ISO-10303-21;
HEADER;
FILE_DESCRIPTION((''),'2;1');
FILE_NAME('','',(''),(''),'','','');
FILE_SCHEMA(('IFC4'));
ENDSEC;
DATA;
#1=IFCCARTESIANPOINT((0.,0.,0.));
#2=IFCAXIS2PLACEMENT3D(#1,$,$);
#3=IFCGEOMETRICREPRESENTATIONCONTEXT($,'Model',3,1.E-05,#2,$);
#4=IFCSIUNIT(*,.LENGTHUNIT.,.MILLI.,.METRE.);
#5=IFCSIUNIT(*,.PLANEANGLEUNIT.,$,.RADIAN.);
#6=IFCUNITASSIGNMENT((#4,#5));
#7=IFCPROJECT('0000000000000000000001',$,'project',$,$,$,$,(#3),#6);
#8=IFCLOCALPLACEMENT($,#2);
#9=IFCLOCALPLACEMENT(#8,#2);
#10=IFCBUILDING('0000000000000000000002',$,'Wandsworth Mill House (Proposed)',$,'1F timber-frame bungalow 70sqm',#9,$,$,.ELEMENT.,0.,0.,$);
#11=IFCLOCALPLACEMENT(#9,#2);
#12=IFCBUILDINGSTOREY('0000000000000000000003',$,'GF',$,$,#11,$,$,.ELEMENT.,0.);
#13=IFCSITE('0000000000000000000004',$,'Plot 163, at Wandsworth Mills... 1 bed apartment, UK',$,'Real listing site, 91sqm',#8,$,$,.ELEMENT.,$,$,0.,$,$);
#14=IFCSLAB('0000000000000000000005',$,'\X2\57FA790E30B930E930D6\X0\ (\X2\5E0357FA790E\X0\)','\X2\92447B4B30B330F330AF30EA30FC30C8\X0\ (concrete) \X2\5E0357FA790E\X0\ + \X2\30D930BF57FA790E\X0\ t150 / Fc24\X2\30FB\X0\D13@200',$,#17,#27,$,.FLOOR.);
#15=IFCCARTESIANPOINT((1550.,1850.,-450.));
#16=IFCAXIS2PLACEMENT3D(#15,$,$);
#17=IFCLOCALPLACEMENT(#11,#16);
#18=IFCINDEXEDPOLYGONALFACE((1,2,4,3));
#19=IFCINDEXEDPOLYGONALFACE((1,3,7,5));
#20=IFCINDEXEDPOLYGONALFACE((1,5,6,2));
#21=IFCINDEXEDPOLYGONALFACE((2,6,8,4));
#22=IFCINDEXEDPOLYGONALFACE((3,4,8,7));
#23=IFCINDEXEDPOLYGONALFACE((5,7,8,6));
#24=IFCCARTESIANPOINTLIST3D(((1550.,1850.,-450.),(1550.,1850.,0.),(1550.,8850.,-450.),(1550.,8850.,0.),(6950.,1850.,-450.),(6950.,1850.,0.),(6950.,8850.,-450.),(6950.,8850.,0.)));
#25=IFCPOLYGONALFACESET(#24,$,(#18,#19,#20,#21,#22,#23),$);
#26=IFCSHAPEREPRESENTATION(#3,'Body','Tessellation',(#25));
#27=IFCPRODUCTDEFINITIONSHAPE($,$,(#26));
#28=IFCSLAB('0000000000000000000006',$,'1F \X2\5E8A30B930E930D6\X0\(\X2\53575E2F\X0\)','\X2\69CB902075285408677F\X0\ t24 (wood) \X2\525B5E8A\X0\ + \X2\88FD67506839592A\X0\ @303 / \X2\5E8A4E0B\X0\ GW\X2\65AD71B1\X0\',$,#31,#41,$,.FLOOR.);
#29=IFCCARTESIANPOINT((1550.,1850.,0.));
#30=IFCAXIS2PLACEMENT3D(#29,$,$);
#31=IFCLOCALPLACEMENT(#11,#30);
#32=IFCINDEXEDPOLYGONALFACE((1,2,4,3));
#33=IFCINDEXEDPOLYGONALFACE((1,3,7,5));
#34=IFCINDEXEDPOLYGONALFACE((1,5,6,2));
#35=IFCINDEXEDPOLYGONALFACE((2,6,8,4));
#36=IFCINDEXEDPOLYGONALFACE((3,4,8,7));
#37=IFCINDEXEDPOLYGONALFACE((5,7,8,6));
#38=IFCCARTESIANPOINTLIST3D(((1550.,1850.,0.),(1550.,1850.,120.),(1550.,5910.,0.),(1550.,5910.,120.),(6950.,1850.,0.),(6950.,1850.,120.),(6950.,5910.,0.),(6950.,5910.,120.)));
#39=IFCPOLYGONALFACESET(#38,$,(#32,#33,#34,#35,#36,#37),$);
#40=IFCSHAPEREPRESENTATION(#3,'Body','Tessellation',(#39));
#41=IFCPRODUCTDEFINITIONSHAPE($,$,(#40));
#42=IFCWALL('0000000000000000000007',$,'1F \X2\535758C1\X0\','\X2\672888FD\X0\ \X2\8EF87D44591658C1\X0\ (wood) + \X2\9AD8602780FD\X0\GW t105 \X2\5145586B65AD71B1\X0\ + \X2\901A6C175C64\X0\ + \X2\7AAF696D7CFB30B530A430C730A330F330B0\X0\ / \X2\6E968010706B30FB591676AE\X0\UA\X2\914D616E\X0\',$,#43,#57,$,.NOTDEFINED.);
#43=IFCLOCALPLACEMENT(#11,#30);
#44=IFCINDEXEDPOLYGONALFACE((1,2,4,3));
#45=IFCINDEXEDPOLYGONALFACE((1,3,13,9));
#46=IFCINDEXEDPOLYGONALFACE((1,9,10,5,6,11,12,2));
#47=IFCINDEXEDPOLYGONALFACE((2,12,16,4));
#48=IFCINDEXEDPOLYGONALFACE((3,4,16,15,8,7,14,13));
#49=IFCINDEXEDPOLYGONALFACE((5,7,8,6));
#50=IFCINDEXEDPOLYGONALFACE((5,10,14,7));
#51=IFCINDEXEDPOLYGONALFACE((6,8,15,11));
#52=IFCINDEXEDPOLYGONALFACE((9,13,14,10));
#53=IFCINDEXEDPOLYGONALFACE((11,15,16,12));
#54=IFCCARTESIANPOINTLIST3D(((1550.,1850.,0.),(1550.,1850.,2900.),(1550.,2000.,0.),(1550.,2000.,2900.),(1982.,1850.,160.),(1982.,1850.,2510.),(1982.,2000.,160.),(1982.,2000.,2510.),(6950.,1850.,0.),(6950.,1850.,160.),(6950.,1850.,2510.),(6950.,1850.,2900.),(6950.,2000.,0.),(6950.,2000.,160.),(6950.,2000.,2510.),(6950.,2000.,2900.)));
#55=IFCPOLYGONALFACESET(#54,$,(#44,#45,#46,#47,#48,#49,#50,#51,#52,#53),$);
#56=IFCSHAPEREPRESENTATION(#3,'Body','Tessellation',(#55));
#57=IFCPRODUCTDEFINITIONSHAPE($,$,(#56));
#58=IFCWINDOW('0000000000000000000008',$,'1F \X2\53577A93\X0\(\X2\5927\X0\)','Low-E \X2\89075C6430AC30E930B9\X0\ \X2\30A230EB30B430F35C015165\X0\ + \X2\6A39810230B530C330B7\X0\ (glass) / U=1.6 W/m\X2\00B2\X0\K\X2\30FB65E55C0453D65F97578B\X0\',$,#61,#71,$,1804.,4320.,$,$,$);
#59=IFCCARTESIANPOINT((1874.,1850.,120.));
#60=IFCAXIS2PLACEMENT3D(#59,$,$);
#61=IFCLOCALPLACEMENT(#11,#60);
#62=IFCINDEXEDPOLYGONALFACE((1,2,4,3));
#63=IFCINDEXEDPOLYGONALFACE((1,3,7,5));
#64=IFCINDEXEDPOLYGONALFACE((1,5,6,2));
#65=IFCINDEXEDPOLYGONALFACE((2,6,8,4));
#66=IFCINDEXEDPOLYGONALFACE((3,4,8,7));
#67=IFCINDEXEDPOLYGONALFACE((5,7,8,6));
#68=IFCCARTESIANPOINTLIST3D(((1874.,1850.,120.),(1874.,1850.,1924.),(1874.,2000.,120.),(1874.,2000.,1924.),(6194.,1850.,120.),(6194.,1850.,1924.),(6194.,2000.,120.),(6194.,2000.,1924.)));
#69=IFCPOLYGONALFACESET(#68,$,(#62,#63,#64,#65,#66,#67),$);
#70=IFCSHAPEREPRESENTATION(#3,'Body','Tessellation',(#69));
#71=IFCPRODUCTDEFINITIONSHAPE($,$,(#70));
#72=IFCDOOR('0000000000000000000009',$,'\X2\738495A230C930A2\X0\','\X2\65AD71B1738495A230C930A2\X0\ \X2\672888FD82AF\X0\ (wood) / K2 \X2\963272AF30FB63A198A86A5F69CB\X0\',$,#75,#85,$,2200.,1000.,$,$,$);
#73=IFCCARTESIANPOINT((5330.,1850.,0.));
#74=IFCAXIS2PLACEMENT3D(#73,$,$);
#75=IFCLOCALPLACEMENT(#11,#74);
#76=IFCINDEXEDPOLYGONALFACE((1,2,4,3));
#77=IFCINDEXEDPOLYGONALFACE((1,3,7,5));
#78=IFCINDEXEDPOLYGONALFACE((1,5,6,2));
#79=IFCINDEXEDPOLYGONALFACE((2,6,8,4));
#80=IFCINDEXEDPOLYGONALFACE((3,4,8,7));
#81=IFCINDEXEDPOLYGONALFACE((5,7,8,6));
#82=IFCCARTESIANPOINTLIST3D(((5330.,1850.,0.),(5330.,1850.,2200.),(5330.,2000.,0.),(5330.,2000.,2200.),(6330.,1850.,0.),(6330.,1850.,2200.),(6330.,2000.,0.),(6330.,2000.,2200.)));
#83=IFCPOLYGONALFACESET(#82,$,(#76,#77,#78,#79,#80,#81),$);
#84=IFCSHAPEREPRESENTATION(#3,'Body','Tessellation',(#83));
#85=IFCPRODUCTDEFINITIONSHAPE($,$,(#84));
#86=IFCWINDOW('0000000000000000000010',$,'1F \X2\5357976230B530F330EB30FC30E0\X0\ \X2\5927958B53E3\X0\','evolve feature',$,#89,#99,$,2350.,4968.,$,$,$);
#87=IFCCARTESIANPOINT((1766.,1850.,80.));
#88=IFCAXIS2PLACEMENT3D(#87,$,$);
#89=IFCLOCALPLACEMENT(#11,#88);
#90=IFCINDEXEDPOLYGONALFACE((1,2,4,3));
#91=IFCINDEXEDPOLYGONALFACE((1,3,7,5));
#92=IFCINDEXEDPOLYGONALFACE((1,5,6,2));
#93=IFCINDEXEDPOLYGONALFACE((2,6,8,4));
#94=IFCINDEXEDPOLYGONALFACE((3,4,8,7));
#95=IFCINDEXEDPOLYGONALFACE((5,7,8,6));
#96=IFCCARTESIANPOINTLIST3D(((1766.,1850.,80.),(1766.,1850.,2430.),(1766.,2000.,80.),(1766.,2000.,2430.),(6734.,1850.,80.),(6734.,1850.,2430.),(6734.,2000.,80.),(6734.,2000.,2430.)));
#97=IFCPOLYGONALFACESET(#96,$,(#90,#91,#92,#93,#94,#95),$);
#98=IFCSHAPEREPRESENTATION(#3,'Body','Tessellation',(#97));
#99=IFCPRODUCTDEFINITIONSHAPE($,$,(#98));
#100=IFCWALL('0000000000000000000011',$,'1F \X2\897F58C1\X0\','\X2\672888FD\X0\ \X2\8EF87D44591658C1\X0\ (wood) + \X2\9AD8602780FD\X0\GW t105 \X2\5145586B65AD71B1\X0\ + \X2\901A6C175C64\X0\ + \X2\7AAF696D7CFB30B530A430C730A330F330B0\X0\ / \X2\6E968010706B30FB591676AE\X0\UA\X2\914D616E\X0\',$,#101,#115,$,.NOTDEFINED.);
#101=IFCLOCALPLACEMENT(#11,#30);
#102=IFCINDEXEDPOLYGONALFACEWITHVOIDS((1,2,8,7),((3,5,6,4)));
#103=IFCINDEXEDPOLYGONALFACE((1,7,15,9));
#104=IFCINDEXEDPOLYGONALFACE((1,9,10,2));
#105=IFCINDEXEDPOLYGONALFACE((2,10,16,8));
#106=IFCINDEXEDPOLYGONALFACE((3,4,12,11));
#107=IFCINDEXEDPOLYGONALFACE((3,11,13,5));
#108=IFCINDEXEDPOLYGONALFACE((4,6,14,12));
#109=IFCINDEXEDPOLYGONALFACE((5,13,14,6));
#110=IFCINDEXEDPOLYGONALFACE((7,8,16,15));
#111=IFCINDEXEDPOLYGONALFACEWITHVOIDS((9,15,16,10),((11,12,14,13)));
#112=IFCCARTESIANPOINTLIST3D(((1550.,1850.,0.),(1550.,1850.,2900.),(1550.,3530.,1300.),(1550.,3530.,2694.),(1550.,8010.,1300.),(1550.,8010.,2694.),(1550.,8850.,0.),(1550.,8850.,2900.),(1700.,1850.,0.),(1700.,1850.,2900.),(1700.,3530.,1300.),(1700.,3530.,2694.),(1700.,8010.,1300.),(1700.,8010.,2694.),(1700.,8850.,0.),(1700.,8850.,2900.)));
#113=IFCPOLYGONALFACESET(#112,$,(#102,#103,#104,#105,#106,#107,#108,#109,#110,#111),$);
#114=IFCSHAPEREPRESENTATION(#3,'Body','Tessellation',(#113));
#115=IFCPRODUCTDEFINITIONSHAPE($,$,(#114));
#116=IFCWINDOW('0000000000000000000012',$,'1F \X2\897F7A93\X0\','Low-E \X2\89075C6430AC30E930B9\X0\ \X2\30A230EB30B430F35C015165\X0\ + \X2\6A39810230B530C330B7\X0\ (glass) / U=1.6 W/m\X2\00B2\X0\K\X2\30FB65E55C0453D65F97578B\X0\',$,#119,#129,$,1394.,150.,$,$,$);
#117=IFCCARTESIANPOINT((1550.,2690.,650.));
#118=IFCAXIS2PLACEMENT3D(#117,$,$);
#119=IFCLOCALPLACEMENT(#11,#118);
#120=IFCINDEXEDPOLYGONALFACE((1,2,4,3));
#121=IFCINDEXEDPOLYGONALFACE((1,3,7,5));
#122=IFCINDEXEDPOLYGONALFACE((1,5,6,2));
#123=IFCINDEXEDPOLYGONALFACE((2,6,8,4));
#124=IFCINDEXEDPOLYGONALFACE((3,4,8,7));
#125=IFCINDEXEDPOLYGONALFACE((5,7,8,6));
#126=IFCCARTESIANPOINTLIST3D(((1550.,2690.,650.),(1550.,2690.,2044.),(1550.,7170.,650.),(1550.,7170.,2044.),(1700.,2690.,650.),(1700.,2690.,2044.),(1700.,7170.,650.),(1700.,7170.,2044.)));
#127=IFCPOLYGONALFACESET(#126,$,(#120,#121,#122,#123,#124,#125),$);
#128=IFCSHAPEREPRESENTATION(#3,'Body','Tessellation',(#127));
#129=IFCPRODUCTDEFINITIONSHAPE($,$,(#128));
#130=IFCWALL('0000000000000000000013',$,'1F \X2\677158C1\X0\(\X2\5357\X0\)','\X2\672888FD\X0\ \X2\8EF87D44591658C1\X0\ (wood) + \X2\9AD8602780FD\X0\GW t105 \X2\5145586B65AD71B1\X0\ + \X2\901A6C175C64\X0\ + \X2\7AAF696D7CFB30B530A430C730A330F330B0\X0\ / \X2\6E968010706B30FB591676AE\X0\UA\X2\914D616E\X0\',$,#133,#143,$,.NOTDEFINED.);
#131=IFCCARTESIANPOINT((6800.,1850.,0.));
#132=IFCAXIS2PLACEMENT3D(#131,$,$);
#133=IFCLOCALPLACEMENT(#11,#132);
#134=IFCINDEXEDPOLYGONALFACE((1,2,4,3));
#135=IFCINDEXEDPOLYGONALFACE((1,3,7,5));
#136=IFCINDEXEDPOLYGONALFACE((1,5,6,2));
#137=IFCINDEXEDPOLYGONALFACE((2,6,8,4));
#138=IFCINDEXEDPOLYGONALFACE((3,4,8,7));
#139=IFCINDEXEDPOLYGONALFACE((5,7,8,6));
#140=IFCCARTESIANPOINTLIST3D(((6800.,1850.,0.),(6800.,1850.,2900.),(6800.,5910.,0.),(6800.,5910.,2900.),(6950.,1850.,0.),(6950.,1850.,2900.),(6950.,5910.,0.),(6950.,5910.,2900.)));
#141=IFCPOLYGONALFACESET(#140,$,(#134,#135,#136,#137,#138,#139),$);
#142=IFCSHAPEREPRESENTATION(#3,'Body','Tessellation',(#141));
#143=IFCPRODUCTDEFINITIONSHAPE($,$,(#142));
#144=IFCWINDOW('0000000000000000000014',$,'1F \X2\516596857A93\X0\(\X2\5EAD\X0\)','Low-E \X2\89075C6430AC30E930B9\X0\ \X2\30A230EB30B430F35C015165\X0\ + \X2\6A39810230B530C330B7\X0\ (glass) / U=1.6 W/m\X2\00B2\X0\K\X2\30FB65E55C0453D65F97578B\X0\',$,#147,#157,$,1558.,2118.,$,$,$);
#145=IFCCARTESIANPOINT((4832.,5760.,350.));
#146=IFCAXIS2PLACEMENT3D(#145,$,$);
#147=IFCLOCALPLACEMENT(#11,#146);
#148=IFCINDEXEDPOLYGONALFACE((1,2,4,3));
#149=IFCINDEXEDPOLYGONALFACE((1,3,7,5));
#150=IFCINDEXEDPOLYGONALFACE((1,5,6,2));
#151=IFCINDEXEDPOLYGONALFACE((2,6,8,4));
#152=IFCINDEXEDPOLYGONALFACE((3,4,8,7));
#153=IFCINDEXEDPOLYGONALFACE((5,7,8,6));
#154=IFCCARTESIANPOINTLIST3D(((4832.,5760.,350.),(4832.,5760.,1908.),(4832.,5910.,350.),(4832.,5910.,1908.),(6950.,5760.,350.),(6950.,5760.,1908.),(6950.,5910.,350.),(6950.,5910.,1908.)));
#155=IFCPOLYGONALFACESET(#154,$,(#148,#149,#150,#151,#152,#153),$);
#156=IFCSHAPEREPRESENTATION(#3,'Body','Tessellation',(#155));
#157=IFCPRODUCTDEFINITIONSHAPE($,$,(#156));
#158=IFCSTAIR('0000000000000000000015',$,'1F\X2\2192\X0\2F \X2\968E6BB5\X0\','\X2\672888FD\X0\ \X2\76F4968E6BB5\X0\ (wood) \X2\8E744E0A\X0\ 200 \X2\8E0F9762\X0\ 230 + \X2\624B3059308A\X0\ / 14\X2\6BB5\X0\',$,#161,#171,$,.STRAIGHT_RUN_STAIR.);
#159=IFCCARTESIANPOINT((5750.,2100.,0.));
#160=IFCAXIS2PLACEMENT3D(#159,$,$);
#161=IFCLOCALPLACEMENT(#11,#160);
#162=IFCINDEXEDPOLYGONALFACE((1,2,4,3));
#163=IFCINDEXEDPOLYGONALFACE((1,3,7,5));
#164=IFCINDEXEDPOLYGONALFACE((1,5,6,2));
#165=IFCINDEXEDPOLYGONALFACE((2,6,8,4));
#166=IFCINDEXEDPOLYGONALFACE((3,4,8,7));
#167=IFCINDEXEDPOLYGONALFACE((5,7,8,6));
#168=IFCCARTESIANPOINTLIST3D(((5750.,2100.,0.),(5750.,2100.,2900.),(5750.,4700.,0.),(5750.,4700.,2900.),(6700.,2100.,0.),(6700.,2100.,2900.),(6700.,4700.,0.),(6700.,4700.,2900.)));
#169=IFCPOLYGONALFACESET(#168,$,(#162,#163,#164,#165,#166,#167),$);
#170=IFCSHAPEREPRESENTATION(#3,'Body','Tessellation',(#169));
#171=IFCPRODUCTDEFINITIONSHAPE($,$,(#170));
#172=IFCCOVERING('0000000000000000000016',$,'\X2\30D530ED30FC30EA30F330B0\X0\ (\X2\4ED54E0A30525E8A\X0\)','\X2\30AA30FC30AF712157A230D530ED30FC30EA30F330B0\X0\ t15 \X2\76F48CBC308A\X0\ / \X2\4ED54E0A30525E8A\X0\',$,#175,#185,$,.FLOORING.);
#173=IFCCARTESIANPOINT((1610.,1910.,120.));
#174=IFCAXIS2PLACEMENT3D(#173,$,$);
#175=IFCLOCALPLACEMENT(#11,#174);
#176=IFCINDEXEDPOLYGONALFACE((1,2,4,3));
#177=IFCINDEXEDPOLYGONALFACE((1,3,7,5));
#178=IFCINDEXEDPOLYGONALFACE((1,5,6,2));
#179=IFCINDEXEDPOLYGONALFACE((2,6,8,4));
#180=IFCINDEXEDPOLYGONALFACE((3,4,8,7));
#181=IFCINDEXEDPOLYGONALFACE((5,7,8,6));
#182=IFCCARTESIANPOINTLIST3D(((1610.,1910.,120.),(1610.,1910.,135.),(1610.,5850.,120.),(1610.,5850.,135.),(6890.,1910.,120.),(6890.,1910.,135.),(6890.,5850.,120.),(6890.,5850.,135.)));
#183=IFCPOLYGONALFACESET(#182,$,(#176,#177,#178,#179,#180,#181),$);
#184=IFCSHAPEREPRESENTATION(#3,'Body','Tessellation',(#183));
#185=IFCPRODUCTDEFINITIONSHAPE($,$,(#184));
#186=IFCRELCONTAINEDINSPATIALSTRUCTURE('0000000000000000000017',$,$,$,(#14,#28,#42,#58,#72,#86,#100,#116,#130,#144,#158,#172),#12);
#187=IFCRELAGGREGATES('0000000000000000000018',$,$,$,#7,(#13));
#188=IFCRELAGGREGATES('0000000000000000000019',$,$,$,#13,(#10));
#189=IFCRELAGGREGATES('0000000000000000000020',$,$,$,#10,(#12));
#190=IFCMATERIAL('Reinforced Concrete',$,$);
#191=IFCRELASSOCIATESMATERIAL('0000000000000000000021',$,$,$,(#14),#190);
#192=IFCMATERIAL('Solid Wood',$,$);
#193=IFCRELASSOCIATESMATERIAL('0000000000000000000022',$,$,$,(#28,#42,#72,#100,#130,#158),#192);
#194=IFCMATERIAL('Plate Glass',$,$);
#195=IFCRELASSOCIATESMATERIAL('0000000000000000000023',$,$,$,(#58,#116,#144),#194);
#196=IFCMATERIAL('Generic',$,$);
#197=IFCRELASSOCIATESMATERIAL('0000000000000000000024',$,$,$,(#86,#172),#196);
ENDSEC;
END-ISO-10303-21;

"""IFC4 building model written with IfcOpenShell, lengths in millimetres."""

from ifc_helpers import new_model, si_unit, frame, frame_2d, origin, place, context, project, spatial, rectangle, extrude, material, element, fill, save


model = new_model("IFC4")

# Units and contexts
model_context = context("Model", 3, precision=1e-05, world=origin())
ifc_project = project(units=[si_unit("LENGTHUNIT", "METRE", prefix="MILLI"), si_unit("PLANEANGLEUNIT", "RADIAN")], contexts=[model_context])

# Site, building, storey
site_placement = place(None, origin())
site = spatial("IfcSite", under=ifc_project, at=site_placement, Name="Plot 163, at Wandsworth Mills... 1 bed apartment, UK", ObjectType="Real listing site, 91sqm", CompositionType="ELEMENT", RefElevation=0.0)
building_placement = place(site_placement, origin())
building = spatial("IfcBuilding", under=site, at=building_placement, Name="Wandsworth Mill House (Proposed)", ObjectType="1F timber-frame bungalow 70sqm", CompositionType="ELEMENT", ElevationOfRefHeight=0.0, ElevationOfTerrain=0.0)
storey_placement = place(building_placement, origin())
storey = spatial("IfcBuildingStorey", under=building, at=storey_placement, Name="GF", CompositionType="ELEMENT", Elevation=0.0)

# Slabs
ifc_material_1 = material(Name="Reinforced Concrete")
slab_1_placement = place(storey_placement, frame((1550.0, 1850.0, -450.0)))
element("IfcSlab", 1, at=slab_1_placement, inside=storey, material=ifc_material_1, Name="基礎スラブ (布基礎)", Description="鉄筋コンクリート (concrete) 布基礎 + ベタ基礎 t150 / Fc24・D13@200", PredefinedType="FLOOR", context=model_context, shape_type="SweptSolid", body=[
    extrude(rectangle(XDim=5400.0, YDim=7000.0, at=frame_2d((2700.0, 3500.0))), frame((1550.0, 1850.0, -450.0)), (0.0, 0.0, 1.0), 450.0),
])
ifc_material_2 = material(Name="Solid Wood")
slab_2_placement = place(storey_placement, frame((1550.0, 1850.0, 0.0)))
element("IfcSlab", 2, at=slab_2_placement, inside=storey, material=ifc_material_2, Name="1F 床スラブ(南帯)", Description="構造用合板 t24 (wood) 剛床 + 製材根太 @303 / 床下 GW断熱", PredefinedType="FLOOR", context=model_context, shape_type="SweptSolid", body=[
    extrude(rectangle(XDim=5400.0, YDim=4060.0, at=frame_2d((2700.0, 2030.0))), frame((1550.0, 1850.0, 0.0)), (0.0, 0.0, 1.0), 120.0),
])

# Wall, openings, windows, door
wall_1_placement = place(storey_placement, frame((1550.0, 1850.0, 0.0)))
wall_1 = element("IfcWall", 3, at=wall_1_placement, inside=storey, material=ifc_material_2, Name="1F 南壁", Description="木製 軸組外壁 (wood) + 高性能GW t105 充填断熱 + 通気層 + 窯業系サイディング / 準耐火・外皮UA配慮", PredefinedType="NOTDEFINED", context=model_context, shape_type="SweptSolid", body=[
    extrude(rectangle(XDim=5400.0, YDim=150.0, at=frame_2d((2700.0, 75.0))), frame((1550.0, 1850.0, 0.0)), (0.0, 0.0, 1.0), 2900.0),
])
opening_1_placement = place(storey_placement, frame((1874.0, 1850.0, 120.0)))
opening_1 = element("IfcOpeningElement", 4, at=opening_1_placement, cuts=wall_1, PredefinedType="NOTDEFINED", context=model_context, shape_type="SweptSolid", body=[
    extrude(rectangle(XDim=4320.0, YDim=150.0, at=frame_2d((2160.0, 75.0))), frame((1874.0, 1850.0, 120.0)), (0.0, 0.0, 1.0), 1804.0),
])
opening_2_placement = place(storey_placement, frame((5330.0, 1850.0, 0.0)))
opening_2 = element("IfcOpeningElement", 5, at=opening_2_placement, cuts=wall_1, PredefinedType="NOTDEFINED", context=model_context, shape_type="SweptSolid", body=[
    extrude(rectangle(XDim=1000.0, YDim=150.0, at=frame_2d((500.0, 75.0))), frame((5330.0, 1850.0, 0.0)), (0.0, 0.0, 1.0), 2200.0),
])
opening_3_placement = place(storey_placement, frame((1766.0, 1850.0, 80.0)))
opening_3 = element("IfcOpeningElement", 6, at=opening_3_placement, cuts=wall_1, PredefinedType="NOTDEFINED", context=model_context, shape_type="SweptSolid", body=[
    extrude(rectangle(XDim=4968.0, YDim=150.0, at=frame_2d((2484.0, 75.0))), frame((1766.0, 1850.0, 80.0)), (0.0, 0.0, 1.0), 2350.0),
])
ifc_material_3 = material(Name="Plate Glass")
window_1_placement = place(storey_placement, frame((1874.0, 1850.0, 120.0)))
window_1 = element("IfcWindow", 7, at=window_1_placement, inside=storey, material=ifc_material_3, Name="1F 南窓(大)", Description="Low-E 複層ガラス アルゴン封入 + 樹脂サッシ (glass) / U=1.6 W/m²K・日射取得型", OverallHeight=1804.0, OverallWidth=4320.0, context=model_context, shape_type="SweptSolid", body=[
    extrude(rectangle(XDim=4320.0, YDim=150.0, at=frame_2d((2160.0, 75.0))), frame((1874.0, 1850.0, 120.0)), (0.0, 0.0, 1.0), 1804.0),
])
fill(opening_1, window_1)
door_1_placement = place(storey_placement, frame((5330.0, 1850.0, 0.0)))
door_1 = element("IfcDoor", 8, at=door_1_placement, inside=storey, material=ifc_material_2, Name="玄関ドア", Description="断熱玄関ドア 木製芯 (wood) / K2 防犯・採風機構", OverallHeight=2200.0, OverallWidth=1000.0, context=model_context, shape_type="SweptSolid", body=[
    extrude(rectangle(XDim=1000.0, YDim=150.0, at=frame_2d((500.0, 75.0))), frame((5330.0, 1850.0, 0.0)), (0.0, 0.0, 1.0), 2200.0),
])
fill(opening_2, door_1)
ifc_material_4 = material(Name="Generic")
window_2_placement = place(storey_placement, frame((1766.0, 1850.0, 80.0)))
window_2 = element("IfcWindow", 9, at=window_2_placement, inside=storey, material=ifc_material_4, Name="1F 南面サンルーム 大開口", Description="evolve feature", OverallHeight=2350.0, OverallWidth=4968.0, context=model_context, shape_type="SweptSolid", body=[
    extrude(rectangle(XDim=4968.0, YDim=150.0, at=frame_2d((2484.0, 75.0))), frame((1766.0, 1850.0, 80.0)), (0.0, 0.0, 1.0), 2350.0),
])
fill(opening_3, window_2)

# Walls, openings, windows
wall_2_placement = place(storey_placement, frame((1550.0, 1850.0, 0.0)))
wall_2 = element("IfcWall", 10, at=wall_2_placement, inside=storey, material=ifc_material_2, Name="1F 西壁", Description="木製 軸組外壁 (wood) + 高性能GW t105 充填断熱 + 通気層 + 窯業系サイディング / 準耐火・外皮UA配慮", PredefinedType="NOTDEFINED", context=model_context, shape_type="SweptSolid", body=[
    extrude(rectangle(XDim=150.0, YDim=7000.0, at=frame_2d((75.0, 3500.0))), frame((1550.0, 1850.0, 0.0)), (0.0, 0.0, 1.0), 2900.0),
])
opening_4_placement = place(storey_placement, frame((1550.0, 2690.0, 650.0)))
opening_4 = element("IfcOpeningElement", 11, at=opening_4_placement, cuts=wall_2, PredefinedType="NOTDEFINED", context=model_context, shape_type="SweptSolid", body=[
    extrude(rectangle(XDim=150.0, YDim=4480.0, at=frame_2d((75.0, 2240.0))), frame((1550.0, 2690.0, 650.0)), (0.0, 0.0, 1.0), 1394.0),
])
window_3_placement = place(storey_placement, frame((1550.0, 2690.0, 650.0)))
window_3 = element("IfcWindow", 12, at=window_3_placement, inside=storey, material=ifc_material_3, Name="1F 西窓", Description="Low-E 複層ガラス アルゴン封入 + 樹脂サッシ (glass) / U=1.6 W/m²K・日射取得型", OverallHeight=1394.0, OverallWidth=150.0, context=model_context, shape_type="SweptSolid", body=[
    extrude(rectangle(XDim=150.0, YDim=4480.0, at=frame_2d((75.0, 2240.0))), frame((1550.0, 2690.0, 650.0)), (0.0, 0.0, 1.0), 1394.0),
])
fill(opening_4, window_3)
wall_3_placement = place(storey_placement, frame((6800.0, 1850.0, 0.0)))
wall_3 = element("IfcWall", 13, at=wall_3_placement, inside=storey, material=ifc_material_2, Name="1F 東壁(南)", Description="木製 軸組外壁 (wood) + 高性能GW t105 充填断熱 + 通気層 + 窯業系サイディング / 準耐火・外皮UA配慮", PredefinedType="NOTDEFINED", context=model_context, shape_type="SweptSolid", body=[
    extrude(rectangle(XDim=150.0, YDim=4060.0, at=frame_2d((75.0, 2030.0))), frame((6800.0, 1850.0, 0.0)), (0.0, 0.0, 1.0), 2900.0),
])
opening_5_placement = place(storey_placement, frame((4832.0, 5760.0, 350.0)))
opening_5 = element("IfcOpeningElement", 14, at=opening_5_placement, cuts=wall_3, PredefinedType="NOTDEFINED", context=model_context, shape_type="SweptSolid", body=[
    extrude(rectangle(XDim=2118.0, YDim=150.0, at=frame_2d((1059.0, 75.0))), frame((4832.0, 5760.0, 350.0)), (0.0, 0.0, 1.0), 1558.0),
])
window_4_placement = place(storey_placement, frame((4832.0, 5760.0, 350.0)))
window_4 = element("IfcWindow", 15, at=window_4_placement, inside=storey, material=ifc_material_3, Name="1F 入隅窓(庭)", Description="Low-E 複層ガラス アルゴン封入 + 樹脂サッシ (glass) / U=1.6 W/m²K・日射取得型", OverallHeight=1558.0, OverallWidth=2118.0, context=model_context, shape_type="SweptSolid", body=[
    extrude(rectangle(XDim=2118.0, YDim=150.0, at=frame_2d((1059.0, 75.0))), frame((4832.0, 5760.0, 350.0)), (0.0, 0.0, 1.0), 1558.0),
])
fill(opening_5, window_4)

# Stair
stair_placement = place(storey_placement, frame((5750.0, 2100.0, 0.0)))
element("IfcStair", 16, at=stair_placement, inside=storey, material=ifc_material_2, Name="1F→2F 階段", Description="木製 直階段 (wood) 蹴上 200 踏面 230 + 手すり / 14段", PredefinedType="STRAIGHT_RUN_STAIR", context=model_context, shape_type="SweptSolid", body=[
    extrude(rectangle(XDim=950.0, YDim=2600.0, at=frame_2d((475.0, 1300.0))), frame((5750.0, 2100.0, 0.0)), (0.0, 0.0, 1.0), 2900.0),
])

# Covering
covering_placement = place(storey_placement, frame((1610.0, 1910.0, 120.0)))
element("IfcCovering", 17, at=covering_placement, inside=storey, material=ifc_material_4, Name="フローリング (仕上げ床)", Description="オーク無垢フローリング t15 直貼り / 仕上げ床", PredefinedType="FLOORING", context=model_context, shape_type="SweptSolid", body=[
    extrude(rectangle(XDim=5280.0, YDim=3940.0, at=frame_2d((2640.0, 1970.0))), frame((1610.0, 1910.0, 120.0)), (0.0, 0.0, 1.0), 15.0),
])

save(model, "model.ifc")
